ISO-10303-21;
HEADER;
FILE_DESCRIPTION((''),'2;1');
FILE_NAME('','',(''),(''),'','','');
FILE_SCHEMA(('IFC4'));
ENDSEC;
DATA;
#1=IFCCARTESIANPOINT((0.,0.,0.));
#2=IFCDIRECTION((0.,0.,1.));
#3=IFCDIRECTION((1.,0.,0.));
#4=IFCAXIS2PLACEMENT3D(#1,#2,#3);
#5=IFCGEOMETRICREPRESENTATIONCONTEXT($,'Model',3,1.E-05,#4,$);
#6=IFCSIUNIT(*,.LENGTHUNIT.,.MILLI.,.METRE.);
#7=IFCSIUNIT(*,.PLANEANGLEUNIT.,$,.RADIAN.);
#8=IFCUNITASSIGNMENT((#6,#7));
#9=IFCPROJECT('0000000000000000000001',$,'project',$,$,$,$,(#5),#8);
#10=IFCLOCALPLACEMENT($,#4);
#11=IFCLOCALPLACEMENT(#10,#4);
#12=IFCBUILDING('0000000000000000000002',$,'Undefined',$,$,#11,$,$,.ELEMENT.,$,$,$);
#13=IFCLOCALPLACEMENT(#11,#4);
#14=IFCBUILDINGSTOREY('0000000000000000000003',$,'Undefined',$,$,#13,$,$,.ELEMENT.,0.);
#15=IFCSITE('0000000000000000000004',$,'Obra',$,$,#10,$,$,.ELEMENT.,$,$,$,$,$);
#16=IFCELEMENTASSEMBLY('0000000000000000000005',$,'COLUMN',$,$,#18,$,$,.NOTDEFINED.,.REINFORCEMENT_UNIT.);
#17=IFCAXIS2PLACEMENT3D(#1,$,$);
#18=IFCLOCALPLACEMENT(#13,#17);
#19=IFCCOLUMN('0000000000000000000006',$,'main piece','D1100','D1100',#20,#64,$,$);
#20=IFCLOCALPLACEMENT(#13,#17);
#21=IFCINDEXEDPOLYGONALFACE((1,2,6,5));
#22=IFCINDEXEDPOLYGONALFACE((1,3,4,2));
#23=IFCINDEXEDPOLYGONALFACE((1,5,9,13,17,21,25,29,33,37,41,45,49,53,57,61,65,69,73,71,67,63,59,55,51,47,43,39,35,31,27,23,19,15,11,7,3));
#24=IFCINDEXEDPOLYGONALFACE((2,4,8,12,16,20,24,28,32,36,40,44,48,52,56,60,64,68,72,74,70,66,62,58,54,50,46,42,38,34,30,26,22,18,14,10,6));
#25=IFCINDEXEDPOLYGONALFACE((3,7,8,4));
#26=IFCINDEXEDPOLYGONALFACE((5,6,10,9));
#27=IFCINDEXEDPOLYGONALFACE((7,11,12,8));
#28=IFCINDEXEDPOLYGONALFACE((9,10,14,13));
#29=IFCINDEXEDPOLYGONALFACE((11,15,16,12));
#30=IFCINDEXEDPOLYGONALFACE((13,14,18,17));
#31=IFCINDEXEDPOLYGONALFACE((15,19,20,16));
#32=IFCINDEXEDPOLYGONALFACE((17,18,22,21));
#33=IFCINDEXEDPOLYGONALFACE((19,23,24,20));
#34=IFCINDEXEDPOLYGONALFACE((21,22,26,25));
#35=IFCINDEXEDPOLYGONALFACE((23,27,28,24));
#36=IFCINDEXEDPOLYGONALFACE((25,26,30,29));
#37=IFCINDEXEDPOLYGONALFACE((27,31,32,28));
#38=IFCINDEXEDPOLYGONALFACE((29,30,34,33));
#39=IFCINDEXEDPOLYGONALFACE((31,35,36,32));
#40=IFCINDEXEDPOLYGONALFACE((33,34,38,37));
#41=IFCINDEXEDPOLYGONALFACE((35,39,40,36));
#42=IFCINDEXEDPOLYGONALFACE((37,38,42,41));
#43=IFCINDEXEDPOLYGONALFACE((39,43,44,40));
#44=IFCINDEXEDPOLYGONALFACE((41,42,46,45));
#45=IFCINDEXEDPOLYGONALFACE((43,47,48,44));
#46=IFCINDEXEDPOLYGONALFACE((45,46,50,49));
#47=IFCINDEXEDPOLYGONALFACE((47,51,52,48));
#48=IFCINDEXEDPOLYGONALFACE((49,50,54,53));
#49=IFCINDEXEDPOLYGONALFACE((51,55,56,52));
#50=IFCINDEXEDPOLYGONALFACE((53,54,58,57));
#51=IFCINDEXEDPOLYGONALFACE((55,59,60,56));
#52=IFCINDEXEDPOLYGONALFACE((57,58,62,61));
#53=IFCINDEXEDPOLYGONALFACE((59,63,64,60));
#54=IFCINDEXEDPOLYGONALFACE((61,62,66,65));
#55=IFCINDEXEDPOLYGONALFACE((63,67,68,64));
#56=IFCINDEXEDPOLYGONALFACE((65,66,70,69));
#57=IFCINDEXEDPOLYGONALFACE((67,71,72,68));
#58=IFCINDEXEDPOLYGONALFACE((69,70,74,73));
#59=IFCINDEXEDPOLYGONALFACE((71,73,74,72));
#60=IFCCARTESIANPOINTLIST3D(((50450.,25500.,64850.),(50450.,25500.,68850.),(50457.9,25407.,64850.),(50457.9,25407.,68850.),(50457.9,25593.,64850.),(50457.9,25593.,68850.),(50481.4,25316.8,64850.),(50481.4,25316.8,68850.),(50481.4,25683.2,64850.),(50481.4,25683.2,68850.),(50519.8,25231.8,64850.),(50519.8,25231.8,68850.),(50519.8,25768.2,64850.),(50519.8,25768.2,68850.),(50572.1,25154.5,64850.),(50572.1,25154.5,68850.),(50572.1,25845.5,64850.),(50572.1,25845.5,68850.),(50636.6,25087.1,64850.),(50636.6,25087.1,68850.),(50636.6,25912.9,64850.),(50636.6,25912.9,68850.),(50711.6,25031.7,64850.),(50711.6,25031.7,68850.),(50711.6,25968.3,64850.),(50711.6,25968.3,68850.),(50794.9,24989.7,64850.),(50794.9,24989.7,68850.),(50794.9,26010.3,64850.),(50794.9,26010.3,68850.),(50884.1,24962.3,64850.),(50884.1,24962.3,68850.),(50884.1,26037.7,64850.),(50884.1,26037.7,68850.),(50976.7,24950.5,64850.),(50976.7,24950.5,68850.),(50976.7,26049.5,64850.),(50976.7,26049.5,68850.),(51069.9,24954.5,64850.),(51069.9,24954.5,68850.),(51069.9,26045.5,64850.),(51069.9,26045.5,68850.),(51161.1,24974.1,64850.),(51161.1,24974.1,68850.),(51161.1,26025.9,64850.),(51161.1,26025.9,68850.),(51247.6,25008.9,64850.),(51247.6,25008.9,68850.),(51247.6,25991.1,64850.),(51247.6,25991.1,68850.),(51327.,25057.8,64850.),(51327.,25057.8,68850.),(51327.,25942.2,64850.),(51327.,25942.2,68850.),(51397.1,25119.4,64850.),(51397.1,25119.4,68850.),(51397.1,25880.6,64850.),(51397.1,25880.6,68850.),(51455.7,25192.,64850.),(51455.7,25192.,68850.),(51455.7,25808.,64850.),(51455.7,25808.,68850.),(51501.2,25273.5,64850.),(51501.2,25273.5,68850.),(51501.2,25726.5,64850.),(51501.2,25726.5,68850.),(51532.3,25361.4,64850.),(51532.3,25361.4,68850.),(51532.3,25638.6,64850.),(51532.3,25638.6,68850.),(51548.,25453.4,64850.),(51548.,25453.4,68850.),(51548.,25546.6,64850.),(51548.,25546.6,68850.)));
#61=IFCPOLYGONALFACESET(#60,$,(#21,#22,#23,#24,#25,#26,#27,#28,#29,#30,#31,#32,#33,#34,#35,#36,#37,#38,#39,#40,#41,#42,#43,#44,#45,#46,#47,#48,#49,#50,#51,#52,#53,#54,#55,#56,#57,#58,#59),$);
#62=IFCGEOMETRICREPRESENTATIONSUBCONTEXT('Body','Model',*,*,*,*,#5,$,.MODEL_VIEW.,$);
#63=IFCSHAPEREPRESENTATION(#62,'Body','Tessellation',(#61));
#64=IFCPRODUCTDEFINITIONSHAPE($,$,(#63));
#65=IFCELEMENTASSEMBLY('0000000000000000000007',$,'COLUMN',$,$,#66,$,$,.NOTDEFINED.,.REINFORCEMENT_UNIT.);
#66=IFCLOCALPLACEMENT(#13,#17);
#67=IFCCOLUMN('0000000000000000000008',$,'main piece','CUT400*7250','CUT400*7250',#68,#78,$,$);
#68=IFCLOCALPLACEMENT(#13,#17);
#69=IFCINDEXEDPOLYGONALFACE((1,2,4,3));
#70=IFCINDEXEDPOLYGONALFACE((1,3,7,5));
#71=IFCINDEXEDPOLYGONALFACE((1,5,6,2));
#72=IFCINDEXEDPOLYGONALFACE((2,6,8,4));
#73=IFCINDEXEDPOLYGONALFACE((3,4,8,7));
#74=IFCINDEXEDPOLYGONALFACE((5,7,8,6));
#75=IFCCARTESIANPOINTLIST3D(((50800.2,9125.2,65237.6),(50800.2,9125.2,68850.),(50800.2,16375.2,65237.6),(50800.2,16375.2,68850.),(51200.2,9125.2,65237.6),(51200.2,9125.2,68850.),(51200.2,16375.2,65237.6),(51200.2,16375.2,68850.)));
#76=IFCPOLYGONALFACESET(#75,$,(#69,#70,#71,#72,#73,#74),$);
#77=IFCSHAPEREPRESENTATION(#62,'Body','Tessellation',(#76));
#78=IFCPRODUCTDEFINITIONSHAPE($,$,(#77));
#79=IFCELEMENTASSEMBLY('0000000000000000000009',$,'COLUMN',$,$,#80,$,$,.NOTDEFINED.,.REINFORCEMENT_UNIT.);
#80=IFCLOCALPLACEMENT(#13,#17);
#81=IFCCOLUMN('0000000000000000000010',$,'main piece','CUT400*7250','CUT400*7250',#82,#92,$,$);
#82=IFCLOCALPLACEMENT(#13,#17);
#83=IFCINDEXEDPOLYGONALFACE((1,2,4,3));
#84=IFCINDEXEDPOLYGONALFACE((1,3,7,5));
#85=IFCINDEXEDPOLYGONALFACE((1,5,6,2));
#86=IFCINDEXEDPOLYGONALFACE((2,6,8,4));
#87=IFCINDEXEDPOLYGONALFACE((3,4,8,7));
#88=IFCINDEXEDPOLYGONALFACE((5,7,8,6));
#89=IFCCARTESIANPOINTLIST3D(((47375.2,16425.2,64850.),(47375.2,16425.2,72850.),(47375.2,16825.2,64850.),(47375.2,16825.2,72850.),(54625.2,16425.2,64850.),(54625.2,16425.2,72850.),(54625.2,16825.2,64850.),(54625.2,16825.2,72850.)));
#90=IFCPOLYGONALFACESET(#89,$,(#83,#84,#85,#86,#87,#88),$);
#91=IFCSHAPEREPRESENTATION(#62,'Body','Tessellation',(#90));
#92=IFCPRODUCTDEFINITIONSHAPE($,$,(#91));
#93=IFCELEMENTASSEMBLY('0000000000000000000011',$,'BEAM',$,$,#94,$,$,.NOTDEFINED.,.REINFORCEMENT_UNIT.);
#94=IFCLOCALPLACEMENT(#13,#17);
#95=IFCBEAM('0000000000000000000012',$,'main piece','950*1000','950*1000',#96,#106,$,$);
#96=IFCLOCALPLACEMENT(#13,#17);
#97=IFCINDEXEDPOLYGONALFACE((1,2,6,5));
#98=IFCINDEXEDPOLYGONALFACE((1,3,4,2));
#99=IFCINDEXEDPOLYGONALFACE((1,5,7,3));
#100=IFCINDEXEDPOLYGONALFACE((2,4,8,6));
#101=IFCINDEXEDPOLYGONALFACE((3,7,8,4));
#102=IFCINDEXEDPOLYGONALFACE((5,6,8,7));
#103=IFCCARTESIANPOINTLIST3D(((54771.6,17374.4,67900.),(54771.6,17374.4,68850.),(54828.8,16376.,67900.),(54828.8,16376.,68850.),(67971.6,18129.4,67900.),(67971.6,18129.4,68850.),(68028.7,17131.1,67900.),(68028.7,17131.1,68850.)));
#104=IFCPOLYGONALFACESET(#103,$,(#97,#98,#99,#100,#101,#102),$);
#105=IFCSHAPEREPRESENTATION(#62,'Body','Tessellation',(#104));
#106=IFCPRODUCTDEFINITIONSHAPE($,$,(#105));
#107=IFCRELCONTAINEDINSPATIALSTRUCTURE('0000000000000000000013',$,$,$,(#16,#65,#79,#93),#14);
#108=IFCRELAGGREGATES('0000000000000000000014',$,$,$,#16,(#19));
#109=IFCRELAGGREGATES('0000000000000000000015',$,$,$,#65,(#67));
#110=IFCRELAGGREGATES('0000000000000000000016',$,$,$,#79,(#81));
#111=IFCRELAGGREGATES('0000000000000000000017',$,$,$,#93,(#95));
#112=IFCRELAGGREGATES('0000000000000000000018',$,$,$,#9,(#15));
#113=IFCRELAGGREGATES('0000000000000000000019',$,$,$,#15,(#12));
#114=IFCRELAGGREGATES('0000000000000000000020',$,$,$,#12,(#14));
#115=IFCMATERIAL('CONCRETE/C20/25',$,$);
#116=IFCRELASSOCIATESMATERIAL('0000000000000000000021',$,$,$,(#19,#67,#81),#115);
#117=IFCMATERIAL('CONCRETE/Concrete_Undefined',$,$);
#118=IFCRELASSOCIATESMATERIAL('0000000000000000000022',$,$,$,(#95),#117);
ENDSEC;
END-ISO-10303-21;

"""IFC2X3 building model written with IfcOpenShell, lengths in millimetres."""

from ifc_helpers import new_model, si_unit, frame, origin_with_axes, origin_2d_with_axis, place, context, subcontext, project, spatial, rectangle, circle, extrude, material, element, aggregate, save


model = new_model("IFC2X3")

# Units and contexts
model_context = context("Model", 3, precision=1e-05, world=origin_with_axes())
body_context = subcontext(model_context, "Body", "Model", "MODEL_VIEW")
ifc_project = project(units=[si_unit("LENGTHUNIT", "METRE", prefix="MILLI"), si_unit("PLANEANGLEUNIT", "RADIAN")], contexts=[model_context])

# Site, building, storey
site_placement = place(None, origin_with_axes())
site = spatial("IfcSite", under=ifc_project, at=site_placement, Name="Obra", CompositionType="ELEMENT")
building_placement = place(site_placement, origin_with_axes())
building = spatial("IfcBuilding", under=site, at=building_placement, Name="Undefined", CompositionType="ELEMENT")
storey_placement = place(building_placement, origin_with_axes())
storey = spatial("IfcBuildingStorey", under=building, at=storey_placement, Name="Undefined", CompositionType="ELEMENT", Elevation=0.0)

# Element assemblies, columns
ifc_material_1 = material(Name="CONCRETE/C20/25")
assembly_1_placement = place(storey_placement, origin_with_axes())
assembly_1 = element("IfcElementAssembly", 1, at=assembly_1_placement, inside=storey, Name="COLUMN", AssemblyPlace="NOTDEFINED", PredefinedType="REINFORCEMENT_UNIT")
column_1_placement = place(assembly_1_placement, frame((51000.0, 25500.0, 64850.0), z_axis=(0.0, 0.0, 1.0), x_axis=(0.0, 1.0, 0.0)))
column_1 = element("IfcColumn", 2, at=column_1_placement, material=ifc_material_1, Name="main piece", Description="D1100", ObjectType="D1100", context=body_context, shape_type="SweptSolid", body=[
    extrude(circle(Radius=550.0, at=origin_2d_with_axis()), frame((0.0, 0.0, 4000.0), z_axis=(0.0, 0.0, -1.0), x_axis=(0.0, 1.0, 0.0)), (0.0, 0.0, 1.0), 4000.0),
])
aggregate(assembly_1, [column_1])
assembly_2_placement = place(storey_placement, origin_with_axes())
assembly_2 = element("IfcElementAssembly", 3, at=assembly_2_placement, inside=storey, Name="COLUMN", AssemblyPlace="NOTDEFINED", PredefinedType="REINFORCEMENT_UNIT")
column_2_placement = place(assembly_2_placement, frame((51000.2, 12750.2, 65237.6), z_axis=(0.0, 0.0, 1.0), x_axis=(0.0, -1.0, 0.0)))
column_2 = element("IfcColumn", 4, at=column_2_placement, material=ifc_material_1, Name="main piece", Description="CUT400*7250", ObjectType="CUT400*7250", context=body_context, shape_type="SweptSolid", body=[
    extrude(rectangle(XDim=400.0, YDim=7250.0, at=origin_2d_with_axis()), frame((0.0, 0.0, 3612.4), z_axis=(0.0, 0.0, -1.0), x_axis=(0.0, 1.0, 0.0)), (0.0, 0.0, 1.0), 3612.4),
])
aggregate(assembly_2, [column_2])
assembly_3_placement = place(storey_placement, origin_with_axes())
assembly_3 = element("IfcElementAssembly", 5, at=assembly_3_placement, inside=storey, Name="COLUMN", AssemblyPlace="NOTDEFINED", PredefinedType="REINFORCEMENT_UNIT")
column_3_placement = place(assembly_3_placement, frame((51000.2, 16625.2, 64850.0), z_axis=(0.0, 0.0, 1.0), x_axis=(-1.0, 0.0, 0.0)))
column_3 = element("IfcColumn", 6, at=column_3_placement, material=ifc_material_1, Name="main piece", Description="CUT400*7250", ObjectType="CUT400*7250", context=body_context, shape_type="SweptSolid", body=[
    extrude(rectangle(XDim=400.0, YDim=7250.0, at=origin_2d_with_axis()), frame((0.0, 0.0, 8000.0), z_axis=(0.0, 0.0, -1.0), x_axis=(0.0, 1.0, 0.0)), (0.0, 0.0, 1.0), 8000.0),
])
aggregate(assembly_3, [column_3])

# Element assembly, beam
assembly_4_placement = place(storey_placement, origin_with_axes())
assembly_4 = element("IfcElementAssembly", 7, at=assembly_4_placement, inside=storey, Name="BEAM", AssemblyPlace="NOTDEFINED", PredefinedType="REINFORCEMENT_UNIT")
ifc_material_2 = material(Name="CONCRETE/Concrete_Undefined")
beam_1_placement = place(assembly_4_placement, frame((54800.2, 16875.2, 68375.0), z_axis=(0.0, 0.0, 1.0), x_axis=(0.998368, 0.057107, 0.0)))
beam_1 = element("IfcBeam", 8, at=beam_1_placement, material=ifc_material_2, Name="main piece", Description="950*1000", ObjectType="950*1000", context=body_context, shape_type="SweptSolid", body=[
    extrude(rectangle(XDim=1000.0, YDim=950.0, at=origin_2d_with_axis()), frame((13221.6, 0.0, 0.0), z_axis=(-1.0, 0.0, 0.0), x_axis=(0.0, -1.0, 0.0)), (0.0, 0.0, 1.0), 13221.6),
])
aggregate(assembly_4, [beam_1])

save(model, "model.ifc")
